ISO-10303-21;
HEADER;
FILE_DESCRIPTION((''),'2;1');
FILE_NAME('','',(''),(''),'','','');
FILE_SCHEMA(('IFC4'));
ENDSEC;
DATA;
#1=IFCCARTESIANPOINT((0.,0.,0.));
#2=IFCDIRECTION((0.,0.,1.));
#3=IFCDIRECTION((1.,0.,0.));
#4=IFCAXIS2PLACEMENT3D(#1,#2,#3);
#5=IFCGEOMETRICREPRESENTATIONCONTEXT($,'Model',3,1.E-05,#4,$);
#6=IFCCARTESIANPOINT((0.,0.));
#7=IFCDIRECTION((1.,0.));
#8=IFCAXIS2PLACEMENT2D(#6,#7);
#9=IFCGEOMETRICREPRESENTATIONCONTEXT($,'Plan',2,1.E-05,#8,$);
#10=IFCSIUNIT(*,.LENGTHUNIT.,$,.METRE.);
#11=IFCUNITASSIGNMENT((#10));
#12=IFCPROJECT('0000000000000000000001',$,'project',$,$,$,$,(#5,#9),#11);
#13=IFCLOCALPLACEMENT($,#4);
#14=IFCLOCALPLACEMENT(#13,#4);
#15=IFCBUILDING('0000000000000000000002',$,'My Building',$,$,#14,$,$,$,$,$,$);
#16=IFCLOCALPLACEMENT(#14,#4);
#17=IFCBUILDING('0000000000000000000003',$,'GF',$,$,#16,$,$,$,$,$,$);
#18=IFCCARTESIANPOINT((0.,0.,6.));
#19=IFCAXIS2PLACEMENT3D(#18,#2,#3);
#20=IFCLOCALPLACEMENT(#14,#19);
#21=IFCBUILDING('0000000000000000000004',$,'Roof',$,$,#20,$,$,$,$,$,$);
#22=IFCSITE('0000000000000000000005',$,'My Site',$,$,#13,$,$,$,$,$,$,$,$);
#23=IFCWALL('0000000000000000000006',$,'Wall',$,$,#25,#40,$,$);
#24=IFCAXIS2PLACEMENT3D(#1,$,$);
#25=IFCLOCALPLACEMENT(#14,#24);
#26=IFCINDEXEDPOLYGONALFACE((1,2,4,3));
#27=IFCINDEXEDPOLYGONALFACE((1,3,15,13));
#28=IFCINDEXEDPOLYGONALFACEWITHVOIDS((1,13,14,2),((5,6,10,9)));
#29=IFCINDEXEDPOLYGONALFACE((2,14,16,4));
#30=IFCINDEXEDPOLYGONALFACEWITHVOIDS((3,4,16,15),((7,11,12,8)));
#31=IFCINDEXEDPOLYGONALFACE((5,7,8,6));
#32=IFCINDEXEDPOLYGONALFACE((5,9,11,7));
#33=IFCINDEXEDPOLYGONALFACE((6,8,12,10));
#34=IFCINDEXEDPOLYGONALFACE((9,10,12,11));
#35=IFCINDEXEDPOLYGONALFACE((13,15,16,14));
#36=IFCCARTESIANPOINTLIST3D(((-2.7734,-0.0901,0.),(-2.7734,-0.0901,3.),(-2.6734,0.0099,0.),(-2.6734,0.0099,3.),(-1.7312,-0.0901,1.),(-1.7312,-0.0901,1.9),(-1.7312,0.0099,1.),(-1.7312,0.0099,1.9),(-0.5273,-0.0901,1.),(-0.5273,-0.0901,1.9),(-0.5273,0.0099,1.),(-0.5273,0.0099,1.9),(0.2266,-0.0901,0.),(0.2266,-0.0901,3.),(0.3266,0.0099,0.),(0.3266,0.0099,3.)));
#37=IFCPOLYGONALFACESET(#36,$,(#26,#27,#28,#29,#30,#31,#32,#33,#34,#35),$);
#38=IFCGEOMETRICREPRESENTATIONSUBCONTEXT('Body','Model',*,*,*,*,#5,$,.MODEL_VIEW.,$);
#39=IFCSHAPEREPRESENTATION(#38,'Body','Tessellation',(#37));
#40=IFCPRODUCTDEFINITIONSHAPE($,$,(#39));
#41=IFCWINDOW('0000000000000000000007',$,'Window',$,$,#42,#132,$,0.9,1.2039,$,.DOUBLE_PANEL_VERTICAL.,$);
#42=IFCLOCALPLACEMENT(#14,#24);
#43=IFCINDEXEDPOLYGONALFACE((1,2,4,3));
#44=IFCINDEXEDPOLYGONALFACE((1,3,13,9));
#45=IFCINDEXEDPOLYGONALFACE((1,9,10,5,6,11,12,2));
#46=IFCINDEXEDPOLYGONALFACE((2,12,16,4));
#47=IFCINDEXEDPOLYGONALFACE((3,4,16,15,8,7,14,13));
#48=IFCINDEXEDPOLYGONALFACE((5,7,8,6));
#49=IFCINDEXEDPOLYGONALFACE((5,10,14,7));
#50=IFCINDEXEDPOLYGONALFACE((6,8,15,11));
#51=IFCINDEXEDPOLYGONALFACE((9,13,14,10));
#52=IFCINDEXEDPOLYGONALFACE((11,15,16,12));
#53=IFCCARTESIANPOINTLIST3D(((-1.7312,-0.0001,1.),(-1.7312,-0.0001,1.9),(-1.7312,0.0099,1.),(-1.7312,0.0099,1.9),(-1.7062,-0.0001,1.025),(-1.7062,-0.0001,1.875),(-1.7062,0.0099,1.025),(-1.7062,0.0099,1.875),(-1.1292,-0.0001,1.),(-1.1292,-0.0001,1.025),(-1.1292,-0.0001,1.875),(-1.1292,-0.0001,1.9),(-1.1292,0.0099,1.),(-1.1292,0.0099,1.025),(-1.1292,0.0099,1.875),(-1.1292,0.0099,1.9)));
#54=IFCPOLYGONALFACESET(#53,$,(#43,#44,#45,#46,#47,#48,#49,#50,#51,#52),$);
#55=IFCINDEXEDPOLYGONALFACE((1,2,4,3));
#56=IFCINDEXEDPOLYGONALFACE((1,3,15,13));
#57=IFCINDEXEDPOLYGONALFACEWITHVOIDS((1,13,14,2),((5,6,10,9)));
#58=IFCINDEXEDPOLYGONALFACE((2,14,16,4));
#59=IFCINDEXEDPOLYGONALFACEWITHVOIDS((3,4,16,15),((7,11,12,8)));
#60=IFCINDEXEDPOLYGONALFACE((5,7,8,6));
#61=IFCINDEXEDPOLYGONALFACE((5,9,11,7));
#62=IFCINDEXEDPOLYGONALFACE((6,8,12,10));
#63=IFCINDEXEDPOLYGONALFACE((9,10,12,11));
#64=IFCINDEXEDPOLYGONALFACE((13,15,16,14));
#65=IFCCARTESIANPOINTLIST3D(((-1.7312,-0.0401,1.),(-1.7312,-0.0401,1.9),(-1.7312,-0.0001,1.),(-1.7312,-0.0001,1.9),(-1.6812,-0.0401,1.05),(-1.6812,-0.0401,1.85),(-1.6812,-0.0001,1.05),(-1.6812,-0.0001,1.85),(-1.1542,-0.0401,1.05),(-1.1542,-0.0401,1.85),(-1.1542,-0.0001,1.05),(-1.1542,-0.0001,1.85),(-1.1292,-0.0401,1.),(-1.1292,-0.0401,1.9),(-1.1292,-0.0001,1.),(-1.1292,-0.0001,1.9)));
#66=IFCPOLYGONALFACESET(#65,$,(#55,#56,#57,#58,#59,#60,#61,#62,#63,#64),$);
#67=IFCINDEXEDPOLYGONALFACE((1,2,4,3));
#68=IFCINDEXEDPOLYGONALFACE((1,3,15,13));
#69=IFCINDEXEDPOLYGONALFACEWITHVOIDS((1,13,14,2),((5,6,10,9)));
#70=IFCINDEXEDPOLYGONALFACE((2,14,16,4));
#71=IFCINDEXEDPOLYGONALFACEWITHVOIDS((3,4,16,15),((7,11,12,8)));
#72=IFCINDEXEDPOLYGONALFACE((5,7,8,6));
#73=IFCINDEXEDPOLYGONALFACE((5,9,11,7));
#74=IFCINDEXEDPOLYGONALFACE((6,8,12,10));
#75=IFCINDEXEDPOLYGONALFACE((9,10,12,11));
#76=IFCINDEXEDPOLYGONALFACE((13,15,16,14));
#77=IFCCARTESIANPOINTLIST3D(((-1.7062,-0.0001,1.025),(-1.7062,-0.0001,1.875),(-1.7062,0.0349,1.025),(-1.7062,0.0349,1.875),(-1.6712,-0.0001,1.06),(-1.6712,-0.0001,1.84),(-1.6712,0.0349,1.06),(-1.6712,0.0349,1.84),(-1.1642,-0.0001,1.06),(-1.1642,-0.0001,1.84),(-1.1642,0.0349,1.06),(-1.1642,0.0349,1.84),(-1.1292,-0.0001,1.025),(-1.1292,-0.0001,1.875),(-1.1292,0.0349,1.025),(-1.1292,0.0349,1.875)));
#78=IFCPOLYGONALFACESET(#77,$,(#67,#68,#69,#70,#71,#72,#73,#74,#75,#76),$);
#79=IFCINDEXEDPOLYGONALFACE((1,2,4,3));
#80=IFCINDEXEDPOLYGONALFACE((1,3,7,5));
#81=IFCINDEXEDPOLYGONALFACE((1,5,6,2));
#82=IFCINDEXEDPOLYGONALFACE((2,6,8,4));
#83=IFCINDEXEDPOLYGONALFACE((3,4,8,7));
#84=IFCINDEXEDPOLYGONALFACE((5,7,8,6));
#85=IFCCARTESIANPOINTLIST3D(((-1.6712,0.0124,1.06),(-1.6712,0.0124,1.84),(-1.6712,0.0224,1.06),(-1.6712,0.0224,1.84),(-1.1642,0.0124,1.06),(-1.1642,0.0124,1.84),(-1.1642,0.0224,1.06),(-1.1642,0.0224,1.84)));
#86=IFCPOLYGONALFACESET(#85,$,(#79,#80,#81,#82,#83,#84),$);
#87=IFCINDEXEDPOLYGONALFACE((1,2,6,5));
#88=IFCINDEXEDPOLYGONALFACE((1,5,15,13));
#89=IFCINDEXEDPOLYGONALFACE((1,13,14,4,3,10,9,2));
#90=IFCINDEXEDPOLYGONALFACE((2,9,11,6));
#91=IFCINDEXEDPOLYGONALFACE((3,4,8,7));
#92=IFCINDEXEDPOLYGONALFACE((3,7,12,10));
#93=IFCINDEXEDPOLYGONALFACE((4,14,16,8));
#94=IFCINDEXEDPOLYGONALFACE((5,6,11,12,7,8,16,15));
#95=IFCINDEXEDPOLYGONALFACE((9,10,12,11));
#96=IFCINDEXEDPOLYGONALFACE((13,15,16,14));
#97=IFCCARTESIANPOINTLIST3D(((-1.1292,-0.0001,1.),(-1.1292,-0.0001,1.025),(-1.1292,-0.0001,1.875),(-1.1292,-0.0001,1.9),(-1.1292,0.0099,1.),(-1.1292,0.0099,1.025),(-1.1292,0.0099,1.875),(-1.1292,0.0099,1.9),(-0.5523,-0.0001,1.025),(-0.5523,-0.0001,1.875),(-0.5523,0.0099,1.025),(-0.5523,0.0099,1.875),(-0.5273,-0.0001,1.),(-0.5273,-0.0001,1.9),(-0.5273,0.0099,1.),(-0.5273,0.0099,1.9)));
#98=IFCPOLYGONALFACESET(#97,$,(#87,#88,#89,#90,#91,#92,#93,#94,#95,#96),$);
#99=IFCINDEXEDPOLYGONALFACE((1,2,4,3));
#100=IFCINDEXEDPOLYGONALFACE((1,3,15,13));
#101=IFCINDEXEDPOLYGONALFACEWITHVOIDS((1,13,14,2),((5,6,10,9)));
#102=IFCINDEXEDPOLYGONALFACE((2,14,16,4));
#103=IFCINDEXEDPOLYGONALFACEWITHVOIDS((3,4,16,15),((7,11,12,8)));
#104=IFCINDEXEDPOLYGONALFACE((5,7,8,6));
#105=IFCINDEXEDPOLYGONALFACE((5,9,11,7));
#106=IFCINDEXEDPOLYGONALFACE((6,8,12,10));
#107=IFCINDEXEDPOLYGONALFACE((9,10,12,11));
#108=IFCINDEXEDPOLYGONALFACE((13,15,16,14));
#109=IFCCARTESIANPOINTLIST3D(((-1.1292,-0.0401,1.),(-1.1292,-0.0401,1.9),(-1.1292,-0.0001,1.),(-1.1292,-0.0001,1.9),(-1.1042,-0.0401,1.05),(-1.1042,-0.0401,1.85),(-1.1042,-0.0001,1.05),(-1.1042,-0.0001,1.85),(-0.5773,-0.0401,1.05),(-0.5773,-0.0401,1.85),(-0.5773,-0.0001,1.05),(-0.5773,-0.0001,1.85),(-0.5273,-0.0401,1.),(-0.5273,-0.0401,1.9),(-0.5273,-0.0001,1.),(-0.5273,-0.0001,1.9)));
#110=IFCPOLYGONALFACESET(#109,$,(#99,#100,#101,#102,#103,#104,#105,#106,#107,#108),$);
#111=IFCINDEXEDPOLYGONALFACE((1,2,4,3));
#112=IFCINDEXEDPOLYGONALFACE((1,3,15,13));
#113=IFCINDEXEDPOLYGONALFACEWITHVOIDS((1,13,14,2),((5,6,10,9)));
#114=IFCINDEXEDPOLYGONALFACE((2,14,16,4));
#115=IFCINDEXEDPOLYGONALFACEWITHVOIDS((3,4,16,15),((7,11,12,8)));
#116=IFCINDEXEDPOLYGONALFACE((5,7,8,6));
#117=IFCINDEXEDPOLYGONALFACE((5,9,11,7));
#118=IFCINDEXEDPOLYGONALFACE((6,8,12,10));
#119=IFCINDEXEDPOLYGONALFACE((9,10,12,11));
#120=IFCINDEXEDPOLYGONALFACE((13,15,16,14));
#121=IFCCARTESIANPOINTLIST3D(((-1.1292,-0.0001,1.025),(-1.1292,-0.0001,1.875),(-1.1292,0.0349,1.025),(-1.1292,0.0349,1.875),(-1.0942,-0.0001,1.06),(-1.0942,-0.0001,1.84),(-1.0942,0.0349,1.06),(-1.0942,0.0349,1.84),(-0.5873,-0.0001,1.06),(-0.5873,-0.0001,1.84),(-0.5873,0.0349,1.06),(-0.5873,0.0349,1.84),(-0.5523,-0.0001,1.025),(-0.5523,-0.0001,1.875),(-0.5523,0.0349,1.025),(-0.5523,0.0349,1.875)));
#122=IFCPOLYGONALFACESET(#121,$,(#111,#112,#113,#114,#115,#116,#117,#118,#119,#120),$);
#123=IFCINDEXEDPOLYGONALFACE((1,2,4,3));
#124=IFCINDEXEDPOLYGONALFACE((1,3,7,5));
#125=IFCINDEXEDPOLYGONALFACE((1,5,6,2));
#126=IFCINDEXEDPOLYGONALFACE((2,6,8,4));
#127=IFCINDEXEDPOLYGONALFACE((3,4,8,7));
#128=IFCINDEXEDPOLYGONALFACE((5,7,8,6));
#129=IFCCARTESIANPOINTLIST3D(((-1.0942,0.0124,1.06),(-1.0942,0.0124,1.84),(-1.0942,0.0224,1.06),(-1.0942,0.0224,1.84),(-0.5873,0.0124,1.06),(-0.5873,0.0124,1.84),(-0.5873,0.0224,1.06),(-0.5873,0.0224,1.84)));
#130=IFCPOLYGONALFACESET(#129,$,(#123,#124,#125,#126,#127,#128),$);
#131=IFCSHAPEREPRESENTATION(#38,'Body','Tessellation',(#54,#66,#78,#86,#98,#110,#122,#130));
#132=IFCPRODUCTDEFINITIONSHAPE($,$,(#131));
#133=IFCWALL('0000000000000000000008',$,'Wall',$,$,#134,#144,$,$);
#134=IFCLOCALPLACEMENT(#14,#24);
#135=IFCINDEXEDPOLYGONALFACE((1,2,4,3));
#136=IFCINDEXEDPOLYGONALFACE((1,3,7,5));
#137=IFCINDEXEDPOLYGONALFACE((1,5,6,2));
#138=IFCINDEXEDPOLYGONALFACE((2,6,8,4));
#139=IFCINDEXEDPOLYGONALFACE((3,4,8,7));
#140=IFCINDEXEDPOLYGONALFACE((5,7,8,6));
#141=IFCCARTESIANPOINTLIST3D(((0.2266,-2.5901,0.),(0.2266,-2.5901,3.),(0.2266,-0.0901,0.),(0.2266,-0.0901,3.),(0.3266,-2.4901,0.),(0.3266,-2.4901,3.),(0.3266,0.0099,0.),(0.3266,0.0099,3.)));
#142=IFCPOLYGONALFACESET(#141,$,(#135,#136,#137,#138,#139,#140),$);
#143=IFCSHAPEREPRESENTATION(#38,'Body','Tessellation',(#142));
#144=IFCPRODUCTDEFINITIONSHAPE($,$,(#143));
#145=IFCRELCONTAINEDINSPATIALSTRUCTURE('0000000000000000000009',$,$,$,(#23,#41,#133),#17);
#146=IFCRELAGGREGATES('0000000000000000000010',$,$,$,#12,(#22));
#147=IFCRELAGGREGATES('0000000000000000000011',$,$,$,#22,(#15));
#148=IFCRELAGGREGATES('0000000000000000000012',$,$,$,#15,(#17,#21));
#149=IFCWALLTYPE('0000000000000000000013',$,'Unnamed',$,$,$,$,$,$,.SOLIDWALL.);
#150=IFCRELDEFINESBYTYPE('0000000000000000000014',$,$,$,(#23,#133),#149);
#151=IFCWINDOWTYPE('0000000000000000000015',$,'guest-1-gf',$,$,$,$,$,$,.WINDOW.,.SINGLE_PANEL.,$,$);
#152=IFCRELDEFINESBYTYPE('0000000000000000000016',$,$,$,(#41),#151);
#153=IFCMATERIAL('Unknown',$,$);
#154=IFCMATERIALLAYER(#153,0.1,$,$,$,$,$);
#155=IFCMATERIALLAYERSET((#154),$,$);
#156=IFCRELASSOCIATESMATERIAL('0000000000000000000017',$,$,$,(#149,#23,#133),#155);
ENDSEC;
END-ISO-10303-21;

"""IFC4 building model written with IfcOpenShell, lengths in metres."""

from ifc_helpers import new_model, entity, si_unit, frame, origin_with_axes, origin_2d_with_axis, place, context, subcontext, project, spatial, line, indexed_curve, outline, extrude, shape, source, transform, mapped, material, layer, layer_set, layer_usage, type_object, type_shapes, element, fill, save


model = new_model("IFC4")

# Units and contexts
model_context = context("Model", 3, precision=1e-05, world=origin_with_axes())
plan_context = context("Plan", 2, precision=1e-05, world=origin_2d_with_axis())
body_context_1 = subcontext(model_context, "Body", "Model", "MODEL_VIEW")
body_context_2 = subcontext(plan_context, "Body", "Plan", "PLAN_VIEW")
ifc_project = project(units=[si_unit("LENGTHUNIT", "METRE")], contexts=[model_context, plan_context])

# Site, buildings
site_placement = place(None, origin_with_axes())
site = spatial("IfcSite", under=ifc_project, at=site_placement, Name="My Site")
building_1_placement = place(site_placement, origin_with_axes())
building_1 = spatial("IfcBuilding", under=site, at=building_1_placement, Name="My Building")
building_2_placement = place(building_1_placement, origin_with_axes())
building_2 = spatial("IfcBuilding", under=building_1, at=building_2_placement, Name="GF")

# Shared definitions
ifc_material = material(Name="Unknown")

# Shared definitions
building_3_placement = place(building_1_placement, frame((0.0, 0.0, 6.0), z_axis=(0.0, 0.0, 1.0), x_axis=(1.0, 0.0, 0.0)))
building_3 = spatial("IfcBuilding", under=building_1, at=building_3_placement, Name="Roof")

# Shared definitions
ifc_layer_1 = layer(ifc_material, 0.1)
ifc_layer_set_1 = layer_set([ifc_layer_1])
wall_type = type_object("IfcWallType", Name="Unnamed", PredefinedType="SOLIDWALL", material=ifc_layer_set_1)

# Wall, opening, window
ifc_layer_usage_1 = layer_usage(ifc_layer_set_1, "AXIS2", "POSITIVE", 0.0)
wall_1_placement = place(building_2_placement, frame((-2.7734, -0.0901, 0.0), z_axis=(0.0, 0.0, 1.0), x_axis=(1.0, 0.0, 0.0)))
wall_1 = element("IfcWall", 1, at=wall_1_placement, inside=building_2, type_object=wall_type, material=ifc_layer_usage_1, Name="Wall", context=body_context_1, shape_type="SweptSolid", body=[
    extrude(outline(indexed_curve([(0.0, 0.0), (0.1, 0.1), (3.1, 0.1), (3.0, 0.0)], segments=[line(1, 2, 3, 4, 1)])), origin_with_axes(), (0.0, 0.0, 1.0), 3.0),
])
shared_shape_1 = source(origin_with_axes(), body_context_1, "Body", "SweptSolid", [
    extrude(outline(indexed_curve([(0.0, 0.0), (1.2039, 0.0), (1.2039, 0.9), (0.0, 0.9)], segments=[line(1, 2, 3, 4, 1)])), frame((0.0, -0.6, 0.0), z_axis=(0.0, -1.0, 0.0), x_axis=(1.0, 0.0, 0.0)), (0.0, 0.0, -1.0), 1.2),
])
opening_1_placement = place(wall_1_placement, frame((1.0422, 0.0, 1.0), z_axis=(0.0, 0.0, 1.0), x_axis=(1.0, 0.0, 0.0)))
opening_1 = element("IfcOpeningElement", 2, at=opening_1_placement, cuts=wall_1, PredefinedType="OPENING", context=body_context_1, shape_type="MappedRepresentation", body=[
    mapped(shared_shape_1, transform((0.0, 0.0, 0.0), x_axis=(1.0, 0.0, 0.0), y_axis=(0.0, 1.0, 0.0), z_axis=(0.0, 0.0, 1.0), scale=1.0)),
])
window_type_1 = type_object("IfcWindowType", Name="guest-1-gf", PartitioningType="SINGLE_PANEL", PredefinedType="WINDOW")
shared_shape_2 = source(origin_with_axes(), body_context_1, "Body", "SweptSolid", [
    extrude(outline(indexed_curve([(0.602, 0.0), (0.0, 0.0), (0.0, 0.9), (0.602, 0.9), (0.602, 0.875), (0.025, 0.875), (0.025, 0.025), (0.602, 0.025)], segments=[line(1, 2, 3, 4, 5, 6, 7, 8, 1)])), frame((0.0, 0.09, 0.0), z_axis=(0.0, -1.0, 0.0), x_axis=(1.0, 0.0, 0.0)), (0.0, 0.0, -1.0), 0.01),
    extrude(outline(indexed_curve([(0.0, 0.0), (0.602, 0.0), (0.602, 0.9), (0.0, 0.9)], segments=[line(1, 2, 3, 4, 1)]), holes=[indexed_curve([(0.05, 0.05), (0.577, 0.05), (0.577, 0.85), (0.05, 0.85)], segments=[line(1, 2, 3, 4, 1)])]), frame((0.0, 0.05, 0.0), z_axis=(0.0, -1.0, 0.0), x_axis=(1.0, 0.0, 0.0)), (0.0, 0.0, -1.0), 0.04),
    extrude(outline(indexed_curve([(0.0, 0.0), (0.577, 0.0), (0.577, 0.85), (0.0, 0.85)], segments=[line(1, 2, 3, 4, 1)]), holes=[indexed_curve([(0.035, 0.035), (0.542, 0.035), (0.542, 0.815), (0.035, 0.815)], segments=[line(1, 2, 3, 4, 1)])]), frame((0.025, 0.09, 0.025), z_axis=(0.0, -1.0, 0.0), x_axis=(1.0, 0.0, 0.0)), (0.0, 0.0, -1.0), 0.035),
    extrude(outline(indexed_curve([(0.035, 0.035), (0.542, 0.035), (0.542, 0.815), (0.035, 0.815)], segments=[line(1, 2, 3, 4, 1)])), frame((0.025, 0.1025, 0.025), z_axis=(0.0, -1.0, 0.0), x_axis=(1.0, 0.0, 0.0)), (0.0, 0.0, -1.0), 0.01),
    extrude(outline(indexed_curve([(0.0, 0.9), (0.6019, 0.9), (0.6019, 0.0), (0.0, 0.0), (0.0, 0.025), (0.5769, 0.025), (0.5769, 0.875), (0.0, 0.875)], segments=[line(1, 2, 3, 4, 5, 6, 7, 8, 1)])), frame((0.602, 0.09, 0.0), z_axis=(0.0, -1.0, 0.0), x_axis=(1.0, 0.0, 0.0)), (0.0, 0.0, -1.0), 0.01),
    extrude(outline(indexed_curve([(0.0, 0.0), (0.6019, 0.0), (0.6019, 0.9), (0.0, 0.9)], segments=[line(1, 2, 3, 4, 1)]), holes=[indexed_curve([(0.025, 0.05), (0.5519, 0.05), (0.5519, 0.85), (0.025, 0.85)], segments=[line(1, 2, 3, 4, 1)])]), frame((0.602, 0.05, 0.0), z_axis=(0.0, -1.0, 0.0), x_axis=(1.0, 0.0, 0.0)), (0.0, 0.0, -1.0), 0.04),
    extrude(outline(indexed_curve([(0.0, 0.0), (0.5769, 0.0), (0.5769, 0.85), (0.0, 0.85)], segments=[line(1, 2, 3, 4, 1)]), holes=[indexed_curve([(0.035, 0.035), (0.5419, 0.035), (0.5419, 0.815), (0.035, 0.815)], segments=[line(1, 2, 3, 4, 1)])]), frame((0.602, 0.09, 0.025), z_axis=(0.0, -1.0, 0.0), x_axis=(1.0, 0.0, 0.0)), (0.0, 0.0, -1.0), 0.035),
    extrude(outline(indexed_curve([(0.035, 0.035), (0.5419, 0.035), (0.5419, 0.815), (0.035, 0.815)], segments=[line(1, 2, 3, 4, 1)])), frame((0.602, 0.1025, 0.025), z_axis=(0.0, -1.0, 0.0), x_axis=(1.0, 0.0, 0.0)), (0.0, 0.0, -1.0), 0.01),
])
shared_shape_3 = source(origin_with_axes(), body_context_2, "Body", "Curve2D", [
    entity("IfcIndexedPolyCurve", entity("IfcCartesianPointList2D", [[0.05, 0.05], [0.577, 0.05]])),
    entity("IfcIndexedPolyCurve", entity("IfcCartesianPointList2D", [[0.0, 0.1], [0.025, 0.1], [0.025, 0.09], [0.05, 0.09], [0.05, 0.05], [0.0, 0.05]]), [entity("IfcLineIndex", [1, 2, 3, 4, 5, 6, 1])]),
    entity("IfcIndexedPolyCurve", entity("IfcCartesianPointList2D", [[0.602, 0.1], [0.602, 0.1], [0.602, 0.09], [0.577, 0.09], [0.577, 0.05], [0.602, 0.05]])),
    entity("IfcIndexedPolyCurve", entity("IfcCartesianPointList2D", [[0.025, 0.09], [0.06, 0.09], [0.06, 0.125], [0.025, 0.125]]), [entity("IfcLineIndex", [1, 2, 3, 4, 1])]),
    entity("IfcIndexedPolyCurve", entity("IfcCartesianPointList2D", [[0.602, 0.09], [0.567, 0.09], [0.567, 0.125], [0.602, 0.125]]), [entity("IfcLineIndex", [1, 2, 3, 4, 1])]),
    entity("IfcIndexedPolyCurve", entity("IfcCartesianPointList2D", [[0.06, 0.09], [0.567, 0.09]])),
    entity("IfcIndexedPolyCurve", entity("IfcCartesianPointList2D", [[0.06, 0.125], [0.567, 0.125]])),
    entity("IfcIndexedPolyCurve", entity("IfcCartesianPointList2D", [[0.06, 0.1075], [0.567, 0.1075]])),
    entity("IfcIndexedPolyCurve", entity("IfcCartesianPointList2D", [[0.627, 0.05], [1.1539, 0.05]])),
    entity("IfcIndexedPolyCurve", entity("IfcCartesianPointList2D", [[0.602, 0.1], [0.602, 0.1], [0.602, 0.09], [0.627, 0.09], [0.627, 0.05], [0.602, 0.05]])),
    entity("IfcIndexedPolyCurve", entity("IfcCartesianPointList2D", [[1.2039, 0.1], [1.1789, 0.1], [1.1789, 0.09], [1.1539, 0.09], [1.1539, 0.05], [1.2039, 0.05]]), [entity("IfcLineIndex", [1, 2, 3, 4, 5, 6, 1])]),
    entity("IfcIndexedPolyCurve", entity("IfcCartesianPointList2D", [[0.602, 0.09], [0.637, 0.09], [0.637, 0.125], [0.602, 0.125]]), [entity("IfcLineIndex", [1, 2, 3, 4, 1])]),
    entity("IfcIndexedPolyCurve", entity("IfcCartesianPointList2D", [[1.1789, 0.09], [1.1439, 0.09], [1.1439, 0.125], [1.1789, 0.125]]), [entity("IfcLineIndex", [1, 2, 3, 4, 1])]),
    entity("IfcIndexedPolyCurve", entity("IfcCartesianPointList2D", [[0.637, 0.09], [1.1439, 0.09]])),
    entity("IfcIndexedPolyCurve", entity("IfcCartesianPointList2D", [[0.637, 0.125], [1.1439, 0.125]])),
    entity("IfcIndexedPolyCurve", entity("IfcCartesianPointList2D", [[0.637, 0.1075], [1.1439, 0.1075]])),
])
type_shapes(window_type_1, [shared_shape_2, shared_shape_3])
window_1_placement = place(opening_1_placement, frame((0.0, 0.0, 0.0), z_axis=(0.0, 0.0, 1.0), x_axis=(1.0, 0.0, 0.0)))
window_1 = element("IfcWindow", 3, at=window_1_placement, inside=building_2, type_object=window_type_1, Name="Window", OverallHeight=0.9, OverallWidth=1.2039, PartitioningType="DOUBLE_PANEL_VERTICAL", shapes=[
    shape(body_context_1, "Body", "MappedRepresentation", [mapped(shared_shape_2, transform((0.0, 0.0, 0.0), x_axis=(1.0, 0.0, 0.0), y_axis=(0.0, 1.0, 0.0), z_axis=(0.0, 0.0, 1.0), scale=1.0))]),
    shape(body_context_2, "Body", "MappedRepresentation", [mapped(shared_shape_3, transform((0.0, 0.0, 0.0), x_axis=(1.0, 0.0, 0.0), y_axis=(0.0, 1.0, 0.0), z_axis=(0.0, 0.0, 1.0), scale=1.0))]),
])
fill(opening_1, window_1)

# Wall
ifc_layer_usage_2 = layer_usage(ifc_layer_set_1, "AXIS2", "POSITIVE", 0.0)
wall_2_placement = place(building_2_placement, frame((0.2266, -0.0901, 0.0), z_axis=(0.0, 0.0, 1.0), x_axis=(0.0, -1.0, 0.0)))
element("IfcWall", 4, at=wall_2_placement, inside=building_2, type_object=wall_type, material=ifc_layer_usage_2, Name="Wall", context=body_context_1, shape_type="SweptSolid", body=[
    extrude(outline(indexed_curve([(0.0, 0.0), (-0.1, 0.1), (2.4, 0.1), (2.5, 0.0)], segments=[line(1, 2, 3, 4, 1)])), origin_with_axes(), (0.0, 0.0, 1.0), 3.0),
])

save(model, "model.ifc")
